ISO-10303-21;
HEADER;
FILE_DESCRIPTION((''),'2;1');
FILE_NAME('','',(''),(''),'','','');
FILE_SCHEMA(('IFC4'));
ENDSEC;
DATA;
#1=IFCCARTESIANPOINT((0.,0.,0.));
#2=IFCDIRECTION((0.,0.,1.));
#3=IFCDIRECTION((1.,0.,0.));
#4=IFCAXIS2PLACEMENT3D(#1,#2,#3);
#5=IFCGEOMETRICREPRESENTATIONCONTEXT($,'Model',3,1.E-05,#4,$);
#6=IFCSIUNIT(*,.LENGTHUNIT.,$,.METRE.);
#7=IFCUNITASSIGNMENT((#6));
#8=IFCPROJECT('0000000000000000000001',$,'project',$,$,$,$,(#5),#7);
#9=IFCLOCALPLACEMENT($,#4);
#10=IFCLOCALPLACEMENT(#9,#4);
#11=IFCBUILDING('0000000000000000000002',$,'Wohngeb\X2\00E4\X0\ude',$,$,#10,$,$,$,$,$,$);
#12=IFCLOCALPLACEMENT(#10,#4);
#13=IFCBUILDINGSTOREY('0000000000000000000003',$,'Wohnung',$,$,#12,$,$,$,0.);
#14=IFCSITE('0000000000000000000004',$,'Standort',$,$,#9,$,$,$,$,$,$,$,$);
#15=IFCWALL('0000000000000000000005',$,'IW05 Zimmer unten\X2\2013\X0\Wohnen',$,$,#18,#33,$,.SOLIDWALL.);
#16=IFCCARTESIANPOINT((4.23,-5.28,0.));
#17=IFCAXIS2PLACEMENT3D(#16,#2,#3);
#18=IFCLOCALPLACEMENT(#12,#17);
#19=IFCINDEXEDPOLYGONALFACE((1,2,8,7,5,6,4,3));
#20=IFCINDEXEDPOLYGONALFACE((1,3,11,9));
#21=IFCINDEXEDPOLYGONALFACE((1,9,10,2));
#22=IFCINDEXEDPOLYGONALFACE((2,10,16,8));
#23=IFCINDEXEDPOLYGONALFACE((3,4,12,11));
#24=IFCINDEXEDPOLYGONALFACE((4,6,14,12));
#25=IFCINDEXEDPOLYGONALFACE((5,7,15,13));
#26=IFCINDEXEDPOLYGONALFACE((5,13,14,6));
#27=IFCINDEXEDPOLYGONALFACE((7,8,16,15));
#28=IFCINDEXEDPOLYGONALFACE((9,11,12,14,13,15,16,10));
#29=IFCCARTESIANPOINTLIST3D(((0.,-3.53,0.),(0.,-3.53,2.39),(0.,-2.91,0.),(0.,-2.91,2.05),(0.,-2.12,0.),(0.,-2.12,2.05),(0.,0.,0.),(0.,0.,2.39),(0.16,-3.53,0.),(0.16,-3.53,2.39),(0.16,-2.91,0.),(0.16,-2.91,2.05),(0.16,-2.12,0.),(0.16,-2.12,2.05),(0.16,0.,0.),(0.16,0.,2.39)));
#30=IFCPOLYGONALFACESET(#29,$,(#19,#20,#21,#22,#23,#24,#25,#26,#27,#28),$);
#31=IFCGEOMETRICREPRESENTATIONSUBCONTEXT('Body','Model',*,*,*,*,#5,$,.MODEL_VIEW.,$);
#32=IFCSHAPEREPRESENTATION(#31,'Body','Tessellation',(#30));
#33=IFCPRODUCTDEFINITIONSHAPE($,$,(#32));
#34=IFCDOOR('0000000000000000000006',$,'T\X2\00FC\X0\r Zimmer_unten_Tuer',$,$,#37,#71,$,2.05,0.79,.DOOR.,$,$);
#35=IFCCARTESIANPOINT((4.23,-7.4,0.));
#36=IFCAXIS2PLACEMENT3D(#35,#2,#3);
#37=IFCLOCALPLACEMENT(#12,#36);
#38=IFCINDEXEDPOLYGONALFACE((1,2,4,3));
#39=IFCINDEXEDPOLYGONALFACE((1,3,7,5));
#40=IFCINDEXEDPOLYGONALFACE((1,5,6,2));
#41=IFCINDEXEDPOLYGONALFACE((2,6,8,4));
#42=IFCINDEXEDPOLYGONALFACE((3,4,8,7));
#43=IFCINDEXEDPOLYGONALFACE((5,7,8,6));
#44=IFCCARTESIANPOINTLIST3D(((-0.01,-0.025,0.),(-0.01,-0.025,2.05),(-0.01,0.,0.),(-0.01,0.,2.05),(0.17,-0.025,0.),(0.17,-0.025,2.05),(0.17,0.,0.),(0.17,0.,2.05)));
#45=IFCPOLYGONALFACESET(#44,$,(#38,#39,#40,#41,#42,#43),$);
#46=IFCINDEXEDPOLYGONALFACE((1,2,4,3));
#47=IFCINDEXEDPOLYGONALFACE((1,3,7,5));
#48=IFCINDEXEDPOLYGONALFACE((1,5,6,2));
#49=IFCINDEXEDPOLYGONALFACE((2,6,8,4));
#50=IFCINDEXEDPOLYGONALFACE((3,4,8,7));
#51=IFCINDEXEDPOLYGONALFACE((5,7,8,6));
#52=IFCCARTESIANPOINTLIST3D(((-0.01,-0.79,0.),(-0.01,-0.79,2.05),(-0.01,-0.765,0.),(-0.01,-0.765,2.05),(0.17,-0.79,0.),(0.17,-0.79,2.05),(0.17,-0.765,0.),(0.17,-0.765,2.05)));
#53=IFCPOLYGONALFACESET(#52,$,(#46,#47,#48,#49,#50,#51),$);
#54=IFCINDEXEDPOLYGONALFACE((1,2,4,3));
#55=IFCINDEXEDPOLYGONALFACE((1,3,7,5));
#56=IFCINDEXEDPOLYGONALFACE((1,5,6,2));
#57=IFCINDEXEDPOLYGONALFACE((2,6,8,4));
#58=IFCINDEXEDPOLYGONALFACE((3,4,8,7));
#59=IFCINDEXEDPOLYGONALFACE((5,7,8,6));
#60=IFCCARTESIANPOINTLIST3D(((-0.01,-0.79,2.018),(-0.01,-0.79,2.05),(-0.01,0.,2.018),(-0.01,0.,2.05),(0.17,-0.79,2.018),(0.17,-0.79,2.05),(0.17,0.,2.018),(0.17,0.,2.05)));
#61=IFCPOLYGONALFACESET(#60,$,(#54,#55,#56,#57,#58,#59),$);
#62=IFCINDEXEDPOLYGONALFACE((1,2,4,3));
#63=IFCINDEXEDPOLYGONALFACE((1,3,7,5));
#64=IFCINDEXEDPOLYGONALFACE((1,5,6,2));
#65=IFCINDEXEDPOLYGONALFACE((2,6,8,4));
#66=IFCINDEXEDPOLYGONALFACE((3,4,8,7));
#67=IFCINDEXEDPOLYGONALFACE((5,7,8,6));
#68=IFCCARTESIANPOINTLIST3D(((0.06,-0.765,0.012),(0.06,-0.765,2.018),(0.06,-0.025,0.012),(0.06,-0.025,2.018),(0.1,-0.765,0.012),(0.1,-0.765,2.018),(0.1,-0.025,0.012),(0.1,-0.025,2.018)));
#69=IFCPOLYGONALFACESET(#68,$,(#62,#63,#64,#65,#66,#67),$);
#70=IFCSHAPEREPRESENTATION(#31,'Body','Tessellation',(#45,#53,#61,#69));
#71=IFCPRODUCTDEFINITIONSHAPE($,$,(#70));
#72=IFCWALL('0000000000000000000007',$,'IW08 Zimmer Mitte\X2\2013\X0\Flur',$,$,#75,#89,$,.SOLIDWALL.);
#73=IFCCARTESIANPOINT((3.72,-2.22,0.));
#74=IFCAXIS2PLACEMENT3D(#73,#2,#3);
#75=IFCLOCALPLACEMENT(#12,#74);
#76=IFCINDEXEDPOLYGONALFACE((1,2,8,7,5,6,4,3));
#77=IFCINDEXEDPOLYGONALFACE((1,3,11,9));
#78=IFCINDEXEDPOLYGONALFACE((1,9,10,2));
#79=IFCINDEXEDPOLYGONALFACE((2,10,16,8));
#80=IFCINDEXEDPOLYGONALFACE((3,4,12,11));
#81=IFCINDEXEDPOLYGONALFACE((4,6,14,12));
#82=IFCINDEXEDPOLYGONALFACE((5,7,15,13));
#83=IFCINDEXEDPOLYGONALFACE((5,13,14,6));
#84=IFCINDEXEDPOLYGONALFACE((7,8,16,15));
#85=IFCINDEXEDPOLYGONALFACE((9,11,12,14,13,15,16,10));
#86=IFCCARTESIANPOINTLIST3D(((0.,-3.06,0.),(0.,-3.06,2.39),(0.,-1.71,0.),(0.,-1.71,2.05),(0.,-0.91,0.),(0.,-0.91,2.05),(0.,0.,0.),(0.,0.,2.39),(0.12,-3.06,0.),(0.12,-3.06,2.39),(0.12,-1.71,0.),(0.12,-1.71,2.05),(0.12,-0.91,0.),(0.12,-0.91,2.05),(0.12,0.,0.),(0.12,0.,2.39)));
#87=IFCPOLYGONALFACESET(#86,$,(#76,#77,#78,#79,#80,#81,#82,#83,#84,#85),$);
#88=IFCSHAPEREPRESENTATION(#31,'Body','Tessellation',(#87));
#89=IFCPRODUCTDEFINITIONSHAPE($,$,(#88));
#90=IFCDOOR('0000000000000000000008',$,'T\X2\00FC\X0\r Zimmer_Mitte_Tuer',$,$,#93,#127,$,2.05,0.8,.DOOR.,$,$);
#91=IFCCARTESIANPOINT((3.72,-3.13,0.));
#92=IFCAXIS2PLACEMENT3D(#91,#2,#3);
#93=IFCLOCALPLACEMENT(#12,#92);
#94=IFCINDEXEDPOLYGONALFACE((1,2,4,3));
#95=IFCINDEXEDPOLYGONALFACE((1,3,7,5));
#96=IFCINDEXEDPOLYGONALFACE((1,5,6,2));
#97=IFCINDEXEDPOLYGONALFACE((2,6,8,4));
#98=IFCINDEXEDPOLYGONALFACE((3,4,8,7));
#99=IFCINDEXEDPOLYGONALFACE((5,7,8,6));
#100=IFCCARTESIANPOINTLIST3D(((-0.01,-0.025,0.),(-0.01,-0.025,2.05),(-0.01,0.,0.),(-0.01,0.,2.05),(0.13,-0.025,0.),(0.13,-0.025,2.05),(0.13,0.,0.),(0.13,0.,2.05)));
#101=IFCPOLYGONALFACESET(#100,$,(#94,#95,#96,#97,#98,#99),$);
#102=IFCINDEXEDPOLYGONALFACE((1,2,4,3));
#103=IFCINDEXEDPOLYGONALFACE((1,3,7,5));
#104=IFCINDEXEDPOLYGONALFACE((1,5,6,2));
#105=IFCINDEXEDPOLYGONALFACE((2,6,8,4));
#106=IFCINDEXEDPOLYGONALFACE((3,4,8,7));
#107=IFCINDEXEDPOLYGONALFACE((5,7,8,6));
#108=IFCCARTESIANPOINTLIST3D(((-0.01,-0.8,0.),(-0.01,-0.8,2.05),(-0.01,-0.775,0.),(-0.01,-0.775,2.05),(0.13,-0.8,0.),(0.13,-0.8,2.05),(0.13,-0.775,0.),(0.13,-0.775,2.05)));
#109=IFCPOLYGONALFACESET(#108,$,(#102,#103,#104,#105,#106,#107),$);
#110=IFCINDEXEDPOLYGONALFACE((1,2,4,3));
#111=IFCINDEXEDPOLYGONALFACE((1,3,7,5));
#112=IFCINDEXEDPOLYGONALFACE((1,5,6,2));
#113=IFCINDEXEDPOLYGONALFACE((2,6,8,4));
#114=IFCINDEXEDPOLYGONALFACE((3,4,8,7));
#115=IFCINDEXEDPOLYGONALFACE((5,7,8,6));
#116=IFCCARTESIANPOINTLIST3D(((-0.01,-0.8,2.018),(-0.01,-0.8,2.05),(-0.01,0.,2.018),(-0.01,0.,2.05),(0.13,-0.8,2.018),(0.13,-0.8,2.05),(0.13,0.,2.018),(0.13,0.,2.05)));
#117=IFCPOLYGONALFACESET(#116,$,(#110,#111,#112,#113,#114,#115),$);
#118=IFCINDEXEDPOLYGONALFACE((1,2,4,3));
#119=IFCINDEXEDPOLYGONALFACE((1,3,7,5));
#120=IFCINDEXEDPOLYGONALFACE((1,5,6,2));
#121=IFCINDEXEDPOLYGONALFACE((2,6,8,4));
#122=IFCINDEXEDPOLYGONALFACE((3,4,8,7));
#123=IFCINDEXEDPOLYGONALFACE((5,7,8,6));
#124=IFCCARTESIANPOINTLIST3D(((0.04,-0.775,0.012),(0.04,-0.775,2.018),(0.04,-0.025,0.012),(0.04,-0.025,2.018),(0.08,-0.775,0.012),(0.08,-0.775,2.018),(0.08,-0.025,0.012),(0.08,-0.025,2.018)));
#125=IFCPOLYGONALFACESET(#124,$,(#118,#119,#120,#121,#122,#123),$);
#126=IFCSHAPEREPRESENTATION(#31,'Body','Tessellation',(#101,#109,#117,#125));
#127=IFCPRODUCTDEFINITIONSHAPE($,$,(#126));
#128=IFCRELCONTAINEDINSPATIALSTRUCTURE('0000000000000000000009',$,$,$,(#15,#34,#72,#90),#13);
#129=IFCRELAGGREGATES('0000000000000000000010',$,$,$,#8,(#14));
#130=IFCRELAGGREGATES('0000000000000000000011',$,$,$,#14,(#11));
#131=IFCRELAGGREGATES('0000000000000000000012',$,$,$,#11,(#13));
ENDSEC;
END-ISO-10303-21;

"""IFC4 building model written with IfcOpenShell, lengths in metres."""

from ifc_helpers import new_model, si_unit, frame, origin, origin_with_axes, place, context, subcontext, project, spatial, polyline, outline, extrude, element, fill, save


model = new_model("IFC4")

# Units and contexts
model_context = context("Model", 3, precision=1e-05, world=origin_with_axes())
body_context = subcontext(model_context, "Body", "Model", "MODEL_VIEW")
ifc_project = project(units=[si_unit("LENGTHUNIT", "METRE")], contexts=[model_context])

# Site, building, storey
site_placement = place(None, origin_with_axes())
site = spatial("IfcSite", under=ifc_project, at=site_placement, Name="Standort")
building_placement = place(site_placement, origin_with_axes())
building = spatial("IfcBuilding", under=site, at=building_placement, Name="Wohngebäude")
storey_placement = place(building_placement, origin_with_axes())
storey = spatial("IfcBuildingStorey", under=building, at=storey_placement, Name="Wohnung", Elevation=0.0)

# Wall, opening, door
wall_1_placement = place(storey_placement, frame((4.23, -5.28, 0.0), z_axis=(0.0, 0.0, 1.0), x_axis=(1.0, 0.0, 0.0)))
wall_1 = element("IfcWall", 1, at=wall_1_placement, inside=storey, Name="IW05 Zimmer unten–Wohnen", PredefinedType="SOLIDWALL", context=body_context, shape_type="SweptSolid", body=[
    extrude(outline(polyline([(0.0, 0.0), (0.0, -3.53), (0.16, -3.53), (0.16, 0.0), (0.0, 0.0)])), origin(), (0.0, 0.0, 1.0), 2.39),
])
opening_1_placement = place(wall_1_placement, frame((0.0, -2.12, 0.0), z_axis=(0.0, 0.0, 1.0), x_axis=(1.0, 0.0, 0.0)))
opening_1 = element("IfcOpeningElement", 2, at=opening_1_placement, cuts=wall_1, PredefinedType="OPENING", context=body_context, shape_type="SweptSolid", body=[
    extrude(outline(polyline([(-0.005, 0.0), (-0.005, -0.79), (0.165, -0.79), (0.165, 0.0), (-0.005, 0.0)])), origin(), (0.0, 0.0, 1.0), 2.05),
])
door_1_placement = place(storey_placement, frame((4.23, -7.4, 0.0), z_axis=(0.0, 0.0, 1.0), x_axis=(1.0, 0.0, 0.0)))
door_1 = element("IfcDoor", 3, at=door_1_placement, inside=storey, Name="Tür Zimmer_unten_Tuer", OverallHeight=2.05, OverallWidth=0.79, PredefinedType="DOOR", context=body_context, shape_type="SweptSolid", body=[
    extrude(outline(polyline([(-0.01, 0.0), (-0.01, -0.025), (0.17, -0.025), (0.17, 0.0), (-0.01, 0.0)])), origin(), (0.0, 0.0, 1.0), 2.05),
    extrude(outline(polyline([(-0.01, -0.765), (-0.01, -0.79), (0.17, -0.79), (0.17, -0.765), (-0.01, -0.765)])), origin(), (0.0, 0.0, 1.0), 2.05),
    extrude(outline(polyline([(-0.01, 0.0), (-0.01, -0.79), (0.17, -0.79), (0.17, 0.0), (-0.01, 0.0)])), frame((0.0, 0.0, 2.018)), (0.0, 0.0, 1.0), 0.032),
    extrude(outline(polyline([(0.06, -0.025), (0.06, -0.765), (0.1, -0.765), (0.1, -0.025), (0.06, -0.025)])), frame((0.0, 0.0, 0.012)), (0.0, 0.0, 1.0), 2.006),
])
fill(opening_1, door_1)

# Wall, opening, door
wall_2_placement = place(storey_placement, frame((3.72, -2.22, 0.0), z_axis=(0.0, 0.0, 1.0), x_axis=(1.0, 0.0, 0.0)))
wall_2 = element("IfcWall", 4, at=wall_2_placement, inside=storey, Name="IW08 Zimmer Mitte–Flur", PredefinedType="SOLIDWALL", context=body_context, shape_type="SweptSolid", body=[
    extrude(outline(polyline([(0.0, 0.0), (0.0, -3.06), (0.12, -3.06), (0.12, 0.0), (0.0, 0.0)])), origin(), (0.0, 0.0, 1.0), 2.39),
])
opening_2_placement = place(wall_2_placement, frame((0.0, -0.91, 0.0), z_axis=(0.0, 0.0, 1.0), x_axis=(1.0, 0.0, 0.0)))
opening_2 = element("IfcOpeningElement", 5, at=opening_2_placement, cuts=wall_2, PredefinedType="OPENING", context=body_context, shape_type="SweptSolid", body=[
    extrude(outline(polyline([(-0.005, 0.0), (-0.005, -0.8), (0.125, -0.8), (0.125, 0.0), (-0.005, 0.0)])), origin(), (0.0, 0.0, 1.0), 2.05),
])
door_2_placement = place(storey_placement, frame((3.72, -3.13, 0.0), z_axis=(0.0, 0.0, 1.0), x_axis=(1.0, 0.0, 0.0)))
door_2 = element("IfcDoor", 6, at=door_2_placement, inside=storey, Name="Tür Zimmer_Mitte_Tuer", OverallHeight=2.05, OverallWidth=0.8, PredefinedType="DOOR", context=body_context, shape_type="SweptSolid", body=[
    extrude(outline(polyline([(-0.01, 0.0), (-0.01, -0.025), (0.13, -0.025), (0.13, 0.0), (-0.01, 0.0)])), origin(), (0.0, 0.0, 1.0), 2.05),
    extrude(outline(polyline([(-0.01, -0.775), (-0.01, -0.8), (0.13, -0.8), (0.13, -0.775), (-0.01, -0.775)])), origin(), (0.0, 0.0, 1.0), 2.05),
    extrude(outline(polyline([(-0.01, 0.0), (-0.01, -0.8), (0.13, -0.8), (0.13, 0.0), (-0.01, 0.0)])), frame((0.0, 0.0, 2.018)), (0.0, 0.0, 1.0), 0.032),
    extrude(outline(polyline([(0.04, -0.025), (0.04, -0.775), (0.08, -0.775), (0.08, -0.025), (0.04, -0.025)])), frame((0.0, 0.0, 0.012)), (0.0, 0.0, 1.0), 2.006),
])
fill(opening_2, door_2)

save(model, "model.ifc")
